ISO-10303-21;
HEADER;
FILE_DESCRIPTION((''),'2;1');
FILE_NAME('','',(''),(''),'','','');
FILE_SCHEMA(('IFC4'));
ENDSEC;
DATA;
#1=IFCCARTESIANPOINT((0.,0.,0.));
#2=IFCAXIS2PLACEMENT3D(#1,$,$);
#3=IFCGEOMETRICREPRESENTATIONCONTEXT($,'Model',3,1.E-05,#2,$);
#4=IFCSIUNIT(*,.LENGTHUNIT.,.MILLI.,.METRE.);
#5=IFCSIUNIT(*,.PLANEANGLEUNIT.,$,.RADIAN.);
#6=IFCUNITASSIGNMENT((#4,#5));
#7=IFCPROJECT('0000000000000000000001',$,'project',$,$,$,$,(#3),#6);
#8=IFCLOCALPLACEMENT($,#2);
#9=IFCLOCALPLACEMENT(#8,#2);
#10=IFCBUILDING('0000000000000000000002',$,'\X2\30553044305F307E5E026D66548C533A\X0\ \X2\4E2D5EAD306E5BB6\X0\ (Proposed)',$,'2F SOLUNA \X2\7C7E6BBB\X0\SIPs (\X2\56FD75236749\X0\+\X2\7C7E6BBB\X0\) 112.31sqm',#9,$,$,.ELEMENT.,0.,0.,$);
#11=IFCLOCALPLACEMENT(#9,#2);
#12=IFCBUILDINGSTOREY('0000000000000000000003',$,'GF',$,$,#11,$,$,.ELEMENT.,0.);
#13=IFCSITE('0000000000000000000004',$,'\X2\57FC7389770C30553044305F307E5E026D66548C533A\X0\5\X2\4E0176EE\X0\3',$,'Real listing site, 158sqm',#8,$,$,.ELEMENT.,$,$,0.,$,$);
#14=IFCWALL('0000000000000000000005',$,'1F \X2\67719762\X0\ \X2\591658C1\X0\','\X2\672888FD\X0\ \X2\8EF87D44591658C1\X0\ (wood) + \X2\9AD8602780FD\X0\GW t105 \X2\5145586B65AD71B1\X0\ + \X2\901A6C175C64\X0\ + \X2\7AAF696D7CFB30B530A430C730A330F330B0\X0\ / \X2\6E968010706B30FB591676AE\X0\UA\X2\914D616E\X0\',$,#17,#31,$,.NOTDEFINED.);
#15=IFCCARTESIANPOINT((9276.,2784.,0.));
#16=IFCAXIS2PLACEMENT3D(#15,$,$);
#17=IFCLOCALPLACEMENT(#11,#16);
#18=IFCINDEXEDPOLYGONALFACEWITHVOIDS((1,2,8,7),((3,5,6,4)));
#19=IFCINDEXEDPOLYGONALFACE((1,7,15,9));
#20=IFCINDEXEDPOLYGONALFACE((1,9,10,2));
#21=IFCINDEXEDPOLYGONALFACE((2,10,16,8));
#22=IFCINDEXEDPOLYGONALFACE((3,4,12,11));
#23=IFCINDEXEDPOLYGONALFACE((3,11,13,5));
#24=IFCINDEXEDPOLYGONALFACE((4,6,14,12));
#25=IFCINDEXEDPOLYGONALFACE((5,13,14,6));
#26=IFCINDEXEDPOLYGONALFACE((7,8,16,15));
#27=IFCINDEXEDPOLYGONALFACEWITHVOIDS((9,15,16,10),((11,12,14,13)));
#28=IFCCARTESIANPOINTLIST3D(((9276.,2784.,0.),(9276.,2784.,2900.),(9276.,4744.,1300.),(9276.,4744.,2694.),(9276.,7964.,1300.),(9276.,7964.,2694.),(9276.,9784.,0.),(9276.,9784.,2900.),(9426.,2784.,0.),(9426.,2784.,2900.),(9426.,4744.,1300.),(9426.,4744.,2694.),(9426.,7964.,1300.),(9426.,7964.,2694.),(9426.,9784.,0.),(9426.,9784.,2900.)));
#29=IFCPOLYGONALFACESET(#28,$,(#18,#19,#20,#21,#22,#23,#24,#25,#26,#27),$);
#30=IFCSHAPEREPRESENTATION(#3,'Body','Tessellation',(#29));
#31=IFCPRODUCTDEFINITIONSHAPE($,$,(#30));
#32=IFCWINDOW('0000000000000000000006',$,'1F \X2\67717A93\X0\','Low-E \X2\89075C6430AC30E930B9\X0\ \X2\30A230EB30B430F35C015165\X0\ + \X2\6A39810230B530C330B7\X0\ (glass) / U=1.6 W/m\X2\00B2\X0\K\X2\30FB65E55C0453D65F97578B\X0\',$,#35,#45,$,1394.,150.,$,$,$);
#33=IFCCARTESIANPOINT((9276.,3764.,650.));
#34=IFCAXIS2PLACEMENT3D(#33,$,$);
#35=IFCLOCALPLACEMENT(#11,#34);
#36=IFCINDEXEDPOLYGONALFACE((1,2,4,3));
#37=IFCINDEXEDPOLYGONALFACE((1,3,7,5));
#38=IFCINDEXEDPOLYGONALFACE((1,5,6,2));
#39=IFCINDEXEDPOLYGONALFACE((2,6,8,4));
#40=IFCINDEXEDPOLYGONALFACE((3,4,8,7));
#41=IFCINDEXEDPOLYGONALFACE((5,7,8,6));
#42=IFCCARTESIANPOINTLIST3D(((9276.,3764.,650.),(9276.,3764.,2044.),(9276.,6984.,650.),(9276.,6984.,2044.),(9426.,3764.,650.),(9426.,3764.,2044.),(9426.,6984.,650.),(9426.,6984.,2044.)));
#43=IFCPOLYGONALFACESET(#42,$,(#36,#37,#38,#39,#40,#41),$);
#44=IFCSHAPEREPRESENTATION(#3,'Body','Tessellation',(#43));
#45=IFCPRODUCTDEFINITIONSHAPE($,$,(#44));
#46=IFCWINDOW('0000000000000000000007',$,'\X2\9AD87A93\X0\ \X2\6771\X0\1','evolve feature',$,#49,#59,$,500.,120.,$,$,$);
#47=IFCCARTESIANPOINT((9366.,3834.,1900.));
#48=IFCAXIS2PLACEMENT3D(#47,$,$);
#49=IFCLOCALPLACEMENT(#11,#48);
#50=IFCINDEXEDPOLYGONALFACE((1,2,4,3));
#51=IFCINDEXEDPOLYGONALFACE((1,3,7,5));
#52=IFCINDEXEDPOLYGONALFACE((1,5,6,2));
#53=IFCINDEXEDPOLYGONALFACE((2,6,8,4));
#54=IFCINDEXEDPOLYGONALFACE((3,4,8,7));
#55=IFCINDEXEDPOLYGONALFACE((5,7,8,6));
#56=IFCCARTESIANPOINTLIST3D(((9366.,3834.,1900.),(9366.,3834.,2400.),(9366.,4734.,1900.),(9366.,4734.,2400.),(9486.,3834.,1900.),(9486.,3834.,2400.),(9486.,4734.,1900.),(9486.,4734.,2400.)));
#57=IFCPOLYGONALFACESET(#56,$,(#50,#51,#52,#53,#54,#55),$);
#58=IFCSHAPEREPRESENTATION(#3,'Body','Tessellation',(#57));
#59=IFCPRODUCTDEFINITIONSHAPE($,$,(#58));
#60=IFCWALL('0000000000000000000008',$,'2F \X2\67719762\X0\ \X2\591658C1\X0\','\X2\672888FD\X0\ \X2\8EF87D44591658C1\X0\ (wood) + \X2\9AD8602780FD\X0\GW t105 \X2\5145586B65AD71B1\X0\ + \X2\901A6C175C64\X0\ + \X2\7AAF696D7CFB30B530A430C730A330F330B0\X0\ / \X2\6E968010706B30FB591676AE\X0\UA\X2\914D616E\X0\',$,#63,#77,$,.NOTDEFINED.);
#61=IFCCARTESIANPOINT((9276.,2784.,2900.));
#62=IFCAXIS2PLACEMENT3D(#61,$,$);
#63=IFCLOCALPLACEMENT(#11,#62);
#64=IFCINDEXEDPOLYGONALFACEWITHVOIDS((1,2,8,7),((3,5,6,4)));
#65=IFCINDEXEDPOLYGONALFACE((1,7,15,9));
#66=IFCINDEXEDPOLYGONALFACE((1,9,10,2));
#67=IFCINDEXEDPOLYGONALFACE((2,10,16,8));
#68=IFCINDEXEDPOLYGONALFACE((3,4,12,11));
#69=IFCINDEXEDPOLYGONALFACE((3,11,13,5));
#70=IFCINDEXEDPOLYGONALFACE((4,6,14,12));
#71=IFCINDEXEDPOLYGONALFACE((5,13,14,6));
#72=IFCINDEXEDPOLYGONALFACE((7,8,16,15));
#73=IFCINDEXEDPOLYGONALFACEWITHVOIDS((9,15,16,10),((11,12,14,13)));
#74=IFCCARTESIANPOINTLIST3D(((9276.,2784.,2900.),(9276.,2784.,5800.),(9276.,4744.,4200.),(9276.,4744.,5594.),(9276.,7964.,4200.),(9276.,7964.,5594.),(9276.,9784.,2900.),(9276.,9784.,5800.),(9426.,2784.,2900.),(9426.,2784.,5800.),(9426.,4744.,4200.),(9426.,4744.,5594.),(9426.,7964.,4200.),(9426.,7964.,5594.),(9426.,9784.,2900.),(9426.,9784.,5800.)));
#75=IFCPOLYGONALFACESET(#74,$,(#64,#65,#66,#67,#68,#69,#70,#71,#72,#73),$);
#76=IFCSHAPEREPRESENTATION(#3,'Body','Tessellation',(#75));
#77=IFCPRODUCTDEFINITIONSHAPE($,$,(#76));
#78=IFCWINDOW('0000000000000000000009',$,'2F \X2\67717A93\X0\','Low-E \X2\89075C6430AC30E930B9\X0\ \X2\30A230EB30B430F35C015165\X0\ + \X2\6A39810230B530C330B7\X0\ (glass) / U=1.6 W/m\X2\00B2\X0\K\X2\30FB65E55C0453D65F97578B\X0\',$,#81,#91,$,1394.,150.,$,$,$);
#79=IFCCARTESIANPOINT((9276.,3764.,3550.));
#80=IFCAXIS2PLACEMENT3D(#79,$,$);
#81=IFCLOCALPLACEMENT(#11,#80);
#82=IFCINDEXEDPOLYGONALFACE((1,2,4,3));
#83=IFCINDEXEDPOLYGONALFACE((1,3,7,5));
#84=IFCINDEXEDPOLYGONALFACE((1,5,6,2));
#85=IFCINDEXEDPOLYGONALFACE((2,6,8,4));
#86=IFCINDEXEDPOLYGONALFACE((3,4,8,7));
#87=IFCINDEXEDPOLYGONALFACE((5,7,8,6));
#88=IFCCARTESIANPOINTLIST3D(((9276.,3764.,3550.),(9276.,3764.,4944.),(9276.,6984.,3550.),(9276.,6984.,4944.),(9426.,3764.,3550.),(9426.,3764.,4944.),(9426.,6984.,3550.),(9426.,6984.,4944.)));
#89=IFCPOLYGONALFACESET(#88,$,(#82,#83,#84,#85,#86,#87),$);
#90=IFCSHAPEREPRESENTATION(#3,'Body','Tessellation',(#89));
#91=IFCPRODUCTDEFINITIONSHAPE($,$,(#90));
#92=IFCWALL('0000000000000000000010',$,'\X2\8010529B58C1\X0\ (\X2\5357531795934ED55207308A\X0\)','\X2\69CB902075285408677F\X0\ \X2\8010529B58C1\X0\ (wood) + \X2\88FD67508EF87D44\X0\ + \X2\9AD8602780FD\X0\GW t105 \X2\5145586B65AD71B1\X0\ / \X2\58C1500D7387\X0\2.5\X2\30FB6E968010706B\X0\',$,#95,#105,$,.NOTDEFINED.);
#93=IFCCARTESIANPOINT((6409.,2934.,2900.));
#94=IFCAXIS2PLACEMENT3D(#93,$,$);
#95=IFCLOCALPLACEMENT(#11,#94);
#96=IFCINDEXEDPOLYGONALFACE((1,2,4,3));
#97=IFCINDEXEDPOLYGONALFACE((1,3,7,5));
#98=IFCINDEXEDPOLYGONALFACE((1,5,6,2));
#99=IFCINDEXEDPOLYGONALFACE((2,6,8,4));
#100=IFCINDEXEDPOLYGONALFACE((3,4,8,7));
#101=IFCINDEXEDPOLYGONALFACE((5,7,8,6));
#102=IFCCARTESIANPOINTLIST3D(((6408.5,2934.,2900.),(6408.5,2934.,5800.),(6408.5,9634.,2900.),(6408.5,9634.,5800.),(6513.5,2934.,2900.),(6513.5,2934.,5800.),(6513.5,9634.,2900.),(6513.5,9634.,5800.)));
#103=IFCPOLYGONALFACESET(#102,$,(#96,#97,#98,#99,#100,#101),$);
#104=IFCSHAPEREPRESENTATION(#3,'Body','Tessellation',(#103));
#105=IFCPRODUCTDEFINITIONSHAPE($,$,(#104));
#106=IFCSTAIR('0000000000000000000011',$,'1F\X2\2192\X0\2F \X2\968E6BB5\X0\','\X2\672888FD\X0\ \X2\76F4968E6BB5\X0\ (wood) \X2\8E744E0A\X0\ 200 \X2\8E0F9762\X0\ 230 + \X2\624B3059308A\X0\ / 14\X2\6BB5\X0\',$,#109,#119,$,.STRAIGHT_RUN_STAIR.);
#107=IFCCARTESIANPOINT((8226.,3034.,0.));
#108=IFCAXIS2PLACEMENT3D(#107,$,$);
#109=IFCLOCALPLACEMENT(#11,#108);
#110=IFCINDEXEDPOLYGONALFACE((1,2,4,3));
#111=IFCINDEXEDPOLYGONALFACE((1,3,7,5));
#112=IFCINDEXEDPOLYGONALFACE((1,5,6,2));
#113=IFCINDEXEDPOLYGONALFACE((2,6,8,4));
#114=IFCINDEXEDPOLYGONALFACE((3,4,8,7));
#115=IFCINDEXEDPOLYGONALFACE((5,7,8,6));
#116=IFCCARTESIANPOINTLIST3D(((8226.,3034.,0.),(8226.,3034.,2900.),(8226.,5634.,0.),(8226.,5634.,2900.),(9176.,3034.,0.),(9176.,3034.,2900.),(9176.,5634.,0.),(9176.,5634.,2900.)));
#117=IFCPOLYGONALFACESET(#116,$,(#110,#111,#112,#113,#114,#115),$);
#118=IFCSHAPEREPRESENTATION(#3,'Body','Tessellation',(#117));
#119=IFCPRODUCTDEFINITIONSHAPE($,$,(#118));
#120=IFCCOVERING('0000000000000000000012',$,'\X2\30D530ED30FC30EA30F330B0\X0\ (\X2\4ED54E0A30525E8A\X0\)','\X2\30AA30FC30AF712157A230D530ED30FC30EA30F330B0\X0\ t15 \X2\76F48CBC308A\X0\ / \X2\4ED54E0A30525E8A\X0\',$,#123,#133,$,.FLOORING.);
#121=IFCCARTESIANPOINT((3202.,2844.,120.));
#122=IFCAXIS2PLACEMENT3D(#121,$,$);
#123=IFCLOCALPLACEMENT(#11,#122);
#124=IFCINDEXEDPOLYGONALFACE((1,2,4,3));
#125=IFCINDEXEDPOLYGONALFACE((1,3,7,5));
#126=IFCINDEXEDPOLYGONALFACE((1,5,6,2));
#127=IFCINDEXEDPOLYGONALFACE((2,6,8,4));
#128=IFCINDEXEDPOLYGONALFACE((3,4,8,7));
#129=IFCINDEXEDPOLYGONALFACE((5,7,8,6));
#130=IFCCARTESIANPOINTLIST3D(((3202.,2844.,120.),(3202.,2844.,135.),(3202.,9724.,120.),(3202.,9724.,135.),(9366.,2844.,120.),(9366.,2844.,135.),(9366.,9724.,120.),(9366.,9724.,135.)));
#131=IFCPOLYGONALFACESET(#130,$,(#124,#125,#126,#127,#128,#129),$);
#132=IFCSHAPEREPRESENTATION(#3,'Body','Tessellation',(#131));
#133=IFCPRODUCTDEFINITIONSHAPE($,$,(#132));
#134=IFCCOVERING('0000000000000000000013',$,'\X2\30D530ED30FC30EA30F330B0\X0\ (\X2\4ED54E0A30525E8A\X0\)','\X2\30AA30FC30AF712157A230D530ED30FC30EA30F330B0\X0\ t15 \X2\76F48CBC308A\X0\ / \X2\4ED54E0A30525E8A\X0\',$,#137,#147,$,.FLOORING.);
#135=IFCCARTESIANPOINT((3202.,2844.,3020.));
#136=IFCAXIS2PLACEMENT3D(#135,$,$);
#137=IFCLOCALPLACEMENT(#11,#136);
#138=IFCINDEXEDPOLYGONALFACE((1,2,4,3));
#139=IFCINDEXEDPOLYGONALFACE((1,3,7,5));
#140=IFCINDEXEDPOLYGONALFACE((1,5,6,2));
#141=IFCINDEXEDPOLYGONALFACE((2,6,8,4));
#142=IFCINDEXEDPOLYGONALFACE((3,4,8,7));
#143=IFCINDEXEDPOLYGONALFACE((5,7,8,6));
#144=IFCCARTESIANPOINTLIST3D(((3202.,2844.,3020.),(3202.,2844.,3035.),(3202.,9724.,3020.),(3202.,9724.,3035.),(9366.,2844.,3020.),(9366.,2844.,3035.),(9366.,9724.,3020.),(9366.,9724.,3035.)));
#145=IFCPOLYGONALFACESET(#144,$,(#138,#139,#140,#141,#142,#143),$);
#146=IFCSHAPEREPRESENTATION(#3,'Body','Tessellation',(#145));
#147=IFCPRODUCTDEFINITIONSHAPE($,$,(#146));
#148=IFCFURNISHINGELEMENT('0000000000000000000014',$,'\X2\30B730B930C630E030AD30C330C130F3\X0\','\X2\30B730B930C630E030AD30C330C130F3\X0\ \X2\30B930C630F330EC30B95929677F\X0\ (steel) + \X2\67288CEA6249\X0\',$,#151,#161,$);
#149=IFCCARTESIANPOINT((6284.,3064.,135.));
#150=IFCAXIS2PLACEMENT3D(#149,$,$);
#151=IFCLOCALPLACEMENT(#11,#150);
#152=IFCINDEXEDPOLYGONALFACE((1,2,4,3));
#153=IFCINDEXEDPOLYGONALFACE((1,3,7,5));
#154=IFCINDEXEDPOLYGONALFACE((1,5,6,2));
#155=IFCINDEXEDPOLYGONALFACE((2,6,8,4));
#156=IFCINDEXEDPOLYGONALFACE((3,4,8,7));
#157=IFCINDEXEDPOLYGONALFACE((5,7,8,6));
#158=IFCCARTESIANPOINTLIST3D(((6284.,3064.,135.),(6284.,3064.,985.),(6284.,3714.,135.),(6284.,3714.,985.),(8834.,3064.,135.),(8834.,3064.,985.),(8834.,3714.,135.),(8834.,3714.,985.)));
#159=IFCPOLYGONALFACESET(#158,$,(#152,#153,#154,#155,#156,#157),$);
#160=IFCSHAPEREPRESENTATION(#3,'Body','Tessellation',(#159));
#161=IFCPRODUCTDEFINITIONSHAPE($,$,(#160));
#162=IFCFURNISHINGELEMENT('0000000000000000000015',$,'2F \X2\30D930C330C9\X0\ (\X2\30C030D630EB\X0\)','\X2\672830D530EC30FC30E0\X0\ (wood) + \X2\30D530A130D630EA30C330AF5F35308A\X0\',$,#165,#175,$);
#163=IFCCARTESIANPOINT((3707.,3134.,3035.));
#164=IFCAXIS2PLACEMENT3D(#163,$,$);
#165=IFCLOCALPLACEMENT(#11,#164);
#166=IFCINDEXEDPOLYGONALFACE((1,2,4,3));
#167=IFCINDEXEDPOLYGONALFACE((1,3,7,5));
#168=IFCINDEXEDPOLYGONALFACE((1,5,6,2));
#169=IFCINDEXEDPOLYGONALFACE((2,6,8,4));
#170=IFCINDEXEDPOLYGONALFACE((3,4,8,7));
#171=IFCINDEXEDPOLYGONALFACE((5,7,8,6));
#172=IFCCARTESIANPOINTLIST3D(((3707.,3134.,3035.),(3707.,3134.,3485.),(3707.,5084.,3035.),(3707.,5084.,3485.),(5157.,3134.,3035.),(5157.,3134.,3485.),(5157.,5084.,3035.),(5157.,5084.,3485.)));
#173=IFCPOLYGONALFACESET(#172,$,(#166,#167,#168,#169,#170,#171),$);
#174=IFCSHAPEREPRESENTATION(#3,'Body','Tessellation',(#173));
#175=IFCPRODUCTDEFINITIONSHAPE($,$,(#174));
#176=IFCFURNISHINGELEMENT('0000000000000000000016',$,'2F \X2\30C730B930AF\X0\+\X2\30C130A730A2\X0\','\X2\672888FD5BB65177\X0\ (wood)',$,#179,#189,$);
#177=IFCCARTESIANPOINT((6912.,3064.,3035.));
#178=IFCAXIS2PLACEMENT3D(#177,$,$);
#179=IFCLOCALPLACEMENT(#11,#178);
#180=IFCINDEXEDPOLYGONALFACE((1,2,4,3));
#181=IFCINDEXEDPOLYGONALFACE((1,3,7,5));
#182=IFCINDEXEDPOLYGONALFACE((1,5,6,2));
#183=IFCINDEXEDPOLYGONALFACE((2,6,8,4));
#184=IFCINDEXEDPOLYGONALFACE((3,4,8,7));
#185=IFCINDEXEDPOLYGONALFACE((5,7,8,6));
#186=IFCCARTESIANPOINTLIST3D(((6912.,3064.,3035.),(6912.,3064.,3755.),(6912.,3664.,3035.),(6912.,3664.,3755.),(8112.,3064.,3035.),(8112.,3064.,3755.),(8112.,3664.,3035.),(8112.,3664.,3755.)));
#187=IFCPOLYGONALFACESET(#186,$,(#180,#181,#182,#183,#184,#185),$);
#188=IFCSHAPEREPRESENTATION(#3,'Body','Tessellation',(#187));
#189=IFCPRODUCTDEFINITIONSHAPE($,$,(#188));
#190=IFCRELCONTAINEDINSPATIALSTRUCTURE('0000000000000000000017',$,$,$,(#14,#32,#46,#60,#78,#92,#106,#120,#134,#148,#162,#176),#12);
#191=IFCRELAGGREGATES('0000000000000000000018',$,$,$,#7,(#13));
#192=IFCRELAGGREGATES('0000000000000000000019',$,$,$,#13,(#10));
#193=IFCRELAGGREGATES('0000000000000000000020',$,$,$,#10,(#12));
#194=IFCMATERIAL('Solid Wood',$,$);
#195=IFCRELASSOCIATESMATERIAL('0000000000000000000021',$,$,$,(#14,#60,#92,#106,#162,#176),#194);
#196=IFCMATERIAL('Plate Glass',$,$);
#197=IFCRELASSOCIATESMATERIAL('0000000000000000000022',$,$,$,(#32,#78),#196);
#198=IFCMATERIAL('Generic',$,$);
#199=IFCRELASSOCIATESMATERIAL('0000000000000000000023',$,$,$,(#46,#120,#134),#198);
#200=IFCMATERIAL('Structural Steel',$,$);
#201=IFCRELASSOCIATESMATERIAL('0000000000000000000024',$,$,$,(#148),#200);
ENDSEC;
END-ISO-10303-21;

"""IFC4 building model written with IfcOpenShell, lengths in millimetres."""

from ifc_helpers import new_model, si_unit, frame, frame_2d, origin, place, context, project, spatial, rectangle, extrude, material, element, fill, save


model = new_model("IFC4")

# Units and contexts
model_context = context("Model", 3, precision=1e-05, world=origin())
ifc_project = project(units=[si_unit("LENGTHUNIT", "METRE", prefix="MILLI"), si_unit("PLANEANGLEUNIT", "RADIAN")], contexts=[model_context])

# Site, building, storey
site_placement = place(None, origin())
site = spatial("IfcSite", under=ifc_project, at=site_placement, Name="埼玉県さいたま市浦和区5丁目3", ObjectType="Real listing site, 158sqm", CompositionType="ELEMENT", RefElevation=0.0)
building_placement = place(site_placement, origin())
building = spatial("IfcBuilding", under=site, at=building_placement, Name="さいたま市浦和区 中庭の家 (Proposed)", ObjectType="2F SOLUNA 籾殻SIPs (国産杉+籾殻) 112.31sqm", CompositionType="ELEMENT", ElevationOfRefHeight=0.0, ElevationOfTerrain=0.0)
storey_placement = place(building_placement, origin())
storey = spatial("IfcBuildingStorey", under=building, at=storey_placement, Name="GF", CompositionType="ELEMENT", Elevation=0.0)

# Shared definitions
ifc_material_1 = material(Name="Solid Wood")

# Wall, openings, windows
wall_1_placement = place(storey_placement, frame((9276.0, 2784.0, 0.0)))
wall_1 = element("IfcWall", 1, at=wall_1_placement, inside=storey, material=ifc_material_1, Name="1F 東面 外壁", Description="木製 軸組外壁 (wood) + 高性能GW t105 充填断熱 + 通気層 + 窯業系サイディング / 準耐火・外皮UA配慮", PredefinedType="NOTDEFINED", context=model_context, shape_type="SweptSolid", body=[
    extrude(rectangle(XDim=150.0, YDim=7000.0, at=frame_2d((75.0, 3500.0))), frame((9276.0, 2784.0, 0.0)), (0.0, 0.0, 1.0), 2900.0),
])
opening_1_placement = place(storey_placement, frame((9276.0, 3764.0, 650.0)))
opening_1 = element("IfcOpeningElement", 2, at=opening_1_placement, cuts=wall_1, PredefinedType="NOTDEFINED", context=model_context, shape_type="SweptSolid", body=[
    extrude(rectangle(XDim=150.0, YDim=3220.0, at=frame_2d((75.0, 1610.0))), frame((9276.0, 3764.0, 650.0)), (0.0, 0.0, 1.0), 1394.0),
])
opening_2_placement = place(storey_placement, frame((9366.0, 3834.0, 1900.0)))
opening_2 = element("IfcOpeningElement", 3, at=opening_2_placement, cuts=wall_1, PredefinedType="NOTDEFINED", context=model_context, shape_type="SweptSolid", body=[
    extrude(rectangle(XDim=120.0, YDim=900.0, at=frame_2d((60.0, 450.0))), frame((9366.0, 3834.0, 1900.0)), (0.0, 0.0, 1.0), 500.0),
])
ifc_material_2 = material(Name="Plate Glass")
window_1_placement = place(storey_placement, frame((9276.0, 3764.0, 650.0)))
window_1 = element("IfcWindow", 4, at=window_1_placement, inside=storey, material=ifc_material_2, Name="1F 東窓", Description="Low-E 複層ガラス アルゴン封入 + 樹脂サッシ (glass) / U=1.6 W/m²K・日射取得型", OverallHeight=1394.0, OverallWidth=150.0, context=model_context, shape_type="SweptSolid", body=[
    extrude(rectangle(XDim=150.0, YDim=3220.0, at=frame_2d((75.0, 1610.0))), frame((9276.0, 3764.0, 650.0)), (0.0, 0.0, 1.0), 1394.0),
])
fill(opening_1, window_1)
ifc_material_3 = material(Name="Generic")
window_2_placement = place(storey_placement, frame((9366.0, 3834.0, 1900.0)))
window_2 = element("IfcWindow", 5, at=window_2_placement, inside=storey, material=ifc_material_3, Name="高窓 東1", Description="evolve feature", OverallHeight=500.0, OverallWidth=120.0, context=model_context, shape_type="SweptSolid", body=[
    extrude(rectangle(XDim=120.0, YDim=900.0, at=frame_2d((60.0, 450.0))), frame((9366.0, 3834.0, 1900.0)), (0.0, 0.0, 1.0), 500.0),
])
fill(opening_2, window_2)

# Wall, opening, window
wall_2_placement = place(storey_placement, frame((9276.0, 2784.0, 2900.0)))
wall_2 = element("IfcWall", 6, at=wall_2_placement, inside=storey, material=ifc_material_1, Name="2F 東面 外壁", Description="木製 軸組外壁 (wood) + 高性能GW t105 充填断熱 + 通気層 + 窯業系サイディング / 準耐火・外皮UA配慮", PredefinedType="NOTDEFINED", context=model_context, shape_type="SweptSolid", body=[
    extrude(rectangle(XDim=150.0, YDim=7000.0, at=frame_2d((75.0, 3500.0))), frame((9276.0, 2784.0, 2900.0)), (0.0, 0.0, 1.0), 2900.0),
])
opening_3_placement = place(storey_placement, frame((9276.0, 3764.0, 3550.0)))
opening_3 = element("IfcOpeningElement", 7, at=opening_3_placement, cuts=wall_2, PredefinedType="NOTDEFINED", context=model_context, shape_type="SweptSolid", body=[
    extrude(rectangle(XDim=150.0, YDim=3220.0, at=frame_2d((75.0, 1610.0))), frame((9276.0, 3764.0, 3550.0)), (0.0, 0.0, 1.0), 1394.0),
])
window_3_placement = place(storey_placement, frame((9276.0, 3764.0, 3550.0)))
window_3 = element("IfcWindow", 8, at=window_3_placement, inside=storey, material=ifc_material_2, Name="2F 東窓", Description="Low-E 複層ガラス アルゴン封入 + 樹脂サッシ (glass) / U=1.6 W/m²K・日射取得型", OverallHeight=1394.0, OverallWidth=150.0, context=model_context, shape_type="SweptSolid", body=[
    extrude(rectangle(XDim=150.0, YDim=3220.0, at=frame_2d((75.0, 1610.0))), frame((9276.0, 3764.0, 3550.0)), (0.0, 0.0, 1.0), 1394.0),
])
fill(opening_3, window_3)

# Wall
wall_3_placement = place(storey_placement, frame((6409.0, 2934.0, 2900.0)))
element("IfcWall", 9, at=wall_3_placement, inside=storey, material=ifc_material_1, Name="耐力壁 (南北間仕切り)", Description="構造用合板 耐力壁 (wood) + 製材軸組 + 高性能GW t105 充填断熱 / 壁倍率2.5・準耐火", PredefinedType="NOTDEFINED", context=model_context, shape_type="SweptSolid", body=[
    extrude(rectangle(XDim=105.0, YDim=6700.0, at=frame_2d((52.0, 3350.0))), frame((6409.0, 2934.0, 2900.0)), (0.0, 0.0, 1.0), 2900.0),
])

# Stair
stair_placement = place(storey_placement, frame((8226.0, 3034.0, 0.0)))
element("IfcStair", 10, at=stair_placement, inside=storey, material=ifc_material_1, Name="1F→2F 階段", Description="木製 直階段 (wood) 蹴上 200 踏面 230 + 手すり / 14段", PredefinedType="STRAIGHT_RUN_STAIR", context=model_context, shape_type="SweptSolid", body=[
    extrude(rectangle(XDim=950.0, YDim=2600.0, at=frame_2d((475.0, 1300.0))), frame((8226.0, 3034.0, 0.0)), (0.0, 0.0, 1.0), 2900.0),
])

# Coverings
covering_1_placement = place(storey_placement, frame((3202.0, 2844.0, 120.0)))
element("IfcCovering", 11, at=covering_1_placement, inside=storey, material=ifc_material_3, Name="フローリング (仕上げ床)", Description="オーク無垢フローリング t15 直貼り / 仕上げ床", PredefinedType="FLOORING", context=model_context, shape_type="SweptSolid", body=[
    extrude(rectangle(XDim=6164.0, YDim=6880.0, at=frame_2d((3082.0, 3440.0))), frame((3202.0, 2844.0, 120.0)), (0.0, 0.0, 1.0), 15.0),
])
covering_2_placement = place(storey_placement, frame((3202.0, 2844.0, 3020.0)))
element("IfcCovering", 12, at=covering_2_placement, inside=storey, material=ifc_material_3, Name="フローリング (仕上げ床)", Description="オーク無垢フローリング t15 直貼り / 仕上げ床", PredefinedType="FLOORING", context=model_context, shape_type="SweptSolid", body=[
    extrude(rectangle(XDim=6164.0, YDim=6880.0, at=frame_2d((3082.0, 3440.0))), frame((3202.0, 2844.0, 3020.0)), (0.0, 0.0, 1.0), 15.0),
])

# Furnishing elements
ifc_material_4 = material(Name="Structural Steel")
furnishing_1_placement = place(storey_placement, frame((6284.0, 3064.0, 135.0)))
element("IfcFurnishingElement", 13, at=furnishing_1_placement, inside=storey, material=ifc_material_4, Name="システムキッチン", Description="システムキッチン ステンレス天板 (steel) + 木質扉", context=model_context, shape_type="SweptSolid", body=[
    extrude(rectangle(XDim=2550.0, YDim=650.0, at=frame_2d((1275.0, 325.0))), frame((6284.0, 3064.0, 135.0)), (0.0, 0.0, 1.0), 850.0),
])
furnishing_2_placement = place(storey_placement, frame((3707.0, 3134.0, 3035.0)))
element("IfcFurnishingElement", 14, at=furnishing_2_placement, inside=storey, material=ifc_material_1, Name="2F ベッド (ダブル)", Description="木フレーム (wood) + ファブリック張り", context=model_context, shape_type="SweptSolid", body=[
    extrude(rectangle(XDim=1450.0, YDim=1950.0, at=frame_2d((725.0, 975.0))), frame((3707.0, 3134.0, 3035.0)), (0.0, 0.0, 1.0), 450.0),
])
furnishing_3_placement = place(storey_placement, frame((6912.0, 3064.0, 3035.0)))
element("IfcFurnishingElement", 15, at=furnishing_3_placement, inside=storey, material=ifc_material_1, Name="2F デスク+チェア", Description="木製家具 (wood)", context=model_context, shape_type="SweptSolid", body=[
    extrude(rectangle(XDim=1200.0, YDim=600.0, at=frame_2d((600.0, 300.0))), frame((6912.0, 3064.0, 3035.0)), (0.0, 0.0, 1.0), 720.0),
])

save(model, "model.ifc")
